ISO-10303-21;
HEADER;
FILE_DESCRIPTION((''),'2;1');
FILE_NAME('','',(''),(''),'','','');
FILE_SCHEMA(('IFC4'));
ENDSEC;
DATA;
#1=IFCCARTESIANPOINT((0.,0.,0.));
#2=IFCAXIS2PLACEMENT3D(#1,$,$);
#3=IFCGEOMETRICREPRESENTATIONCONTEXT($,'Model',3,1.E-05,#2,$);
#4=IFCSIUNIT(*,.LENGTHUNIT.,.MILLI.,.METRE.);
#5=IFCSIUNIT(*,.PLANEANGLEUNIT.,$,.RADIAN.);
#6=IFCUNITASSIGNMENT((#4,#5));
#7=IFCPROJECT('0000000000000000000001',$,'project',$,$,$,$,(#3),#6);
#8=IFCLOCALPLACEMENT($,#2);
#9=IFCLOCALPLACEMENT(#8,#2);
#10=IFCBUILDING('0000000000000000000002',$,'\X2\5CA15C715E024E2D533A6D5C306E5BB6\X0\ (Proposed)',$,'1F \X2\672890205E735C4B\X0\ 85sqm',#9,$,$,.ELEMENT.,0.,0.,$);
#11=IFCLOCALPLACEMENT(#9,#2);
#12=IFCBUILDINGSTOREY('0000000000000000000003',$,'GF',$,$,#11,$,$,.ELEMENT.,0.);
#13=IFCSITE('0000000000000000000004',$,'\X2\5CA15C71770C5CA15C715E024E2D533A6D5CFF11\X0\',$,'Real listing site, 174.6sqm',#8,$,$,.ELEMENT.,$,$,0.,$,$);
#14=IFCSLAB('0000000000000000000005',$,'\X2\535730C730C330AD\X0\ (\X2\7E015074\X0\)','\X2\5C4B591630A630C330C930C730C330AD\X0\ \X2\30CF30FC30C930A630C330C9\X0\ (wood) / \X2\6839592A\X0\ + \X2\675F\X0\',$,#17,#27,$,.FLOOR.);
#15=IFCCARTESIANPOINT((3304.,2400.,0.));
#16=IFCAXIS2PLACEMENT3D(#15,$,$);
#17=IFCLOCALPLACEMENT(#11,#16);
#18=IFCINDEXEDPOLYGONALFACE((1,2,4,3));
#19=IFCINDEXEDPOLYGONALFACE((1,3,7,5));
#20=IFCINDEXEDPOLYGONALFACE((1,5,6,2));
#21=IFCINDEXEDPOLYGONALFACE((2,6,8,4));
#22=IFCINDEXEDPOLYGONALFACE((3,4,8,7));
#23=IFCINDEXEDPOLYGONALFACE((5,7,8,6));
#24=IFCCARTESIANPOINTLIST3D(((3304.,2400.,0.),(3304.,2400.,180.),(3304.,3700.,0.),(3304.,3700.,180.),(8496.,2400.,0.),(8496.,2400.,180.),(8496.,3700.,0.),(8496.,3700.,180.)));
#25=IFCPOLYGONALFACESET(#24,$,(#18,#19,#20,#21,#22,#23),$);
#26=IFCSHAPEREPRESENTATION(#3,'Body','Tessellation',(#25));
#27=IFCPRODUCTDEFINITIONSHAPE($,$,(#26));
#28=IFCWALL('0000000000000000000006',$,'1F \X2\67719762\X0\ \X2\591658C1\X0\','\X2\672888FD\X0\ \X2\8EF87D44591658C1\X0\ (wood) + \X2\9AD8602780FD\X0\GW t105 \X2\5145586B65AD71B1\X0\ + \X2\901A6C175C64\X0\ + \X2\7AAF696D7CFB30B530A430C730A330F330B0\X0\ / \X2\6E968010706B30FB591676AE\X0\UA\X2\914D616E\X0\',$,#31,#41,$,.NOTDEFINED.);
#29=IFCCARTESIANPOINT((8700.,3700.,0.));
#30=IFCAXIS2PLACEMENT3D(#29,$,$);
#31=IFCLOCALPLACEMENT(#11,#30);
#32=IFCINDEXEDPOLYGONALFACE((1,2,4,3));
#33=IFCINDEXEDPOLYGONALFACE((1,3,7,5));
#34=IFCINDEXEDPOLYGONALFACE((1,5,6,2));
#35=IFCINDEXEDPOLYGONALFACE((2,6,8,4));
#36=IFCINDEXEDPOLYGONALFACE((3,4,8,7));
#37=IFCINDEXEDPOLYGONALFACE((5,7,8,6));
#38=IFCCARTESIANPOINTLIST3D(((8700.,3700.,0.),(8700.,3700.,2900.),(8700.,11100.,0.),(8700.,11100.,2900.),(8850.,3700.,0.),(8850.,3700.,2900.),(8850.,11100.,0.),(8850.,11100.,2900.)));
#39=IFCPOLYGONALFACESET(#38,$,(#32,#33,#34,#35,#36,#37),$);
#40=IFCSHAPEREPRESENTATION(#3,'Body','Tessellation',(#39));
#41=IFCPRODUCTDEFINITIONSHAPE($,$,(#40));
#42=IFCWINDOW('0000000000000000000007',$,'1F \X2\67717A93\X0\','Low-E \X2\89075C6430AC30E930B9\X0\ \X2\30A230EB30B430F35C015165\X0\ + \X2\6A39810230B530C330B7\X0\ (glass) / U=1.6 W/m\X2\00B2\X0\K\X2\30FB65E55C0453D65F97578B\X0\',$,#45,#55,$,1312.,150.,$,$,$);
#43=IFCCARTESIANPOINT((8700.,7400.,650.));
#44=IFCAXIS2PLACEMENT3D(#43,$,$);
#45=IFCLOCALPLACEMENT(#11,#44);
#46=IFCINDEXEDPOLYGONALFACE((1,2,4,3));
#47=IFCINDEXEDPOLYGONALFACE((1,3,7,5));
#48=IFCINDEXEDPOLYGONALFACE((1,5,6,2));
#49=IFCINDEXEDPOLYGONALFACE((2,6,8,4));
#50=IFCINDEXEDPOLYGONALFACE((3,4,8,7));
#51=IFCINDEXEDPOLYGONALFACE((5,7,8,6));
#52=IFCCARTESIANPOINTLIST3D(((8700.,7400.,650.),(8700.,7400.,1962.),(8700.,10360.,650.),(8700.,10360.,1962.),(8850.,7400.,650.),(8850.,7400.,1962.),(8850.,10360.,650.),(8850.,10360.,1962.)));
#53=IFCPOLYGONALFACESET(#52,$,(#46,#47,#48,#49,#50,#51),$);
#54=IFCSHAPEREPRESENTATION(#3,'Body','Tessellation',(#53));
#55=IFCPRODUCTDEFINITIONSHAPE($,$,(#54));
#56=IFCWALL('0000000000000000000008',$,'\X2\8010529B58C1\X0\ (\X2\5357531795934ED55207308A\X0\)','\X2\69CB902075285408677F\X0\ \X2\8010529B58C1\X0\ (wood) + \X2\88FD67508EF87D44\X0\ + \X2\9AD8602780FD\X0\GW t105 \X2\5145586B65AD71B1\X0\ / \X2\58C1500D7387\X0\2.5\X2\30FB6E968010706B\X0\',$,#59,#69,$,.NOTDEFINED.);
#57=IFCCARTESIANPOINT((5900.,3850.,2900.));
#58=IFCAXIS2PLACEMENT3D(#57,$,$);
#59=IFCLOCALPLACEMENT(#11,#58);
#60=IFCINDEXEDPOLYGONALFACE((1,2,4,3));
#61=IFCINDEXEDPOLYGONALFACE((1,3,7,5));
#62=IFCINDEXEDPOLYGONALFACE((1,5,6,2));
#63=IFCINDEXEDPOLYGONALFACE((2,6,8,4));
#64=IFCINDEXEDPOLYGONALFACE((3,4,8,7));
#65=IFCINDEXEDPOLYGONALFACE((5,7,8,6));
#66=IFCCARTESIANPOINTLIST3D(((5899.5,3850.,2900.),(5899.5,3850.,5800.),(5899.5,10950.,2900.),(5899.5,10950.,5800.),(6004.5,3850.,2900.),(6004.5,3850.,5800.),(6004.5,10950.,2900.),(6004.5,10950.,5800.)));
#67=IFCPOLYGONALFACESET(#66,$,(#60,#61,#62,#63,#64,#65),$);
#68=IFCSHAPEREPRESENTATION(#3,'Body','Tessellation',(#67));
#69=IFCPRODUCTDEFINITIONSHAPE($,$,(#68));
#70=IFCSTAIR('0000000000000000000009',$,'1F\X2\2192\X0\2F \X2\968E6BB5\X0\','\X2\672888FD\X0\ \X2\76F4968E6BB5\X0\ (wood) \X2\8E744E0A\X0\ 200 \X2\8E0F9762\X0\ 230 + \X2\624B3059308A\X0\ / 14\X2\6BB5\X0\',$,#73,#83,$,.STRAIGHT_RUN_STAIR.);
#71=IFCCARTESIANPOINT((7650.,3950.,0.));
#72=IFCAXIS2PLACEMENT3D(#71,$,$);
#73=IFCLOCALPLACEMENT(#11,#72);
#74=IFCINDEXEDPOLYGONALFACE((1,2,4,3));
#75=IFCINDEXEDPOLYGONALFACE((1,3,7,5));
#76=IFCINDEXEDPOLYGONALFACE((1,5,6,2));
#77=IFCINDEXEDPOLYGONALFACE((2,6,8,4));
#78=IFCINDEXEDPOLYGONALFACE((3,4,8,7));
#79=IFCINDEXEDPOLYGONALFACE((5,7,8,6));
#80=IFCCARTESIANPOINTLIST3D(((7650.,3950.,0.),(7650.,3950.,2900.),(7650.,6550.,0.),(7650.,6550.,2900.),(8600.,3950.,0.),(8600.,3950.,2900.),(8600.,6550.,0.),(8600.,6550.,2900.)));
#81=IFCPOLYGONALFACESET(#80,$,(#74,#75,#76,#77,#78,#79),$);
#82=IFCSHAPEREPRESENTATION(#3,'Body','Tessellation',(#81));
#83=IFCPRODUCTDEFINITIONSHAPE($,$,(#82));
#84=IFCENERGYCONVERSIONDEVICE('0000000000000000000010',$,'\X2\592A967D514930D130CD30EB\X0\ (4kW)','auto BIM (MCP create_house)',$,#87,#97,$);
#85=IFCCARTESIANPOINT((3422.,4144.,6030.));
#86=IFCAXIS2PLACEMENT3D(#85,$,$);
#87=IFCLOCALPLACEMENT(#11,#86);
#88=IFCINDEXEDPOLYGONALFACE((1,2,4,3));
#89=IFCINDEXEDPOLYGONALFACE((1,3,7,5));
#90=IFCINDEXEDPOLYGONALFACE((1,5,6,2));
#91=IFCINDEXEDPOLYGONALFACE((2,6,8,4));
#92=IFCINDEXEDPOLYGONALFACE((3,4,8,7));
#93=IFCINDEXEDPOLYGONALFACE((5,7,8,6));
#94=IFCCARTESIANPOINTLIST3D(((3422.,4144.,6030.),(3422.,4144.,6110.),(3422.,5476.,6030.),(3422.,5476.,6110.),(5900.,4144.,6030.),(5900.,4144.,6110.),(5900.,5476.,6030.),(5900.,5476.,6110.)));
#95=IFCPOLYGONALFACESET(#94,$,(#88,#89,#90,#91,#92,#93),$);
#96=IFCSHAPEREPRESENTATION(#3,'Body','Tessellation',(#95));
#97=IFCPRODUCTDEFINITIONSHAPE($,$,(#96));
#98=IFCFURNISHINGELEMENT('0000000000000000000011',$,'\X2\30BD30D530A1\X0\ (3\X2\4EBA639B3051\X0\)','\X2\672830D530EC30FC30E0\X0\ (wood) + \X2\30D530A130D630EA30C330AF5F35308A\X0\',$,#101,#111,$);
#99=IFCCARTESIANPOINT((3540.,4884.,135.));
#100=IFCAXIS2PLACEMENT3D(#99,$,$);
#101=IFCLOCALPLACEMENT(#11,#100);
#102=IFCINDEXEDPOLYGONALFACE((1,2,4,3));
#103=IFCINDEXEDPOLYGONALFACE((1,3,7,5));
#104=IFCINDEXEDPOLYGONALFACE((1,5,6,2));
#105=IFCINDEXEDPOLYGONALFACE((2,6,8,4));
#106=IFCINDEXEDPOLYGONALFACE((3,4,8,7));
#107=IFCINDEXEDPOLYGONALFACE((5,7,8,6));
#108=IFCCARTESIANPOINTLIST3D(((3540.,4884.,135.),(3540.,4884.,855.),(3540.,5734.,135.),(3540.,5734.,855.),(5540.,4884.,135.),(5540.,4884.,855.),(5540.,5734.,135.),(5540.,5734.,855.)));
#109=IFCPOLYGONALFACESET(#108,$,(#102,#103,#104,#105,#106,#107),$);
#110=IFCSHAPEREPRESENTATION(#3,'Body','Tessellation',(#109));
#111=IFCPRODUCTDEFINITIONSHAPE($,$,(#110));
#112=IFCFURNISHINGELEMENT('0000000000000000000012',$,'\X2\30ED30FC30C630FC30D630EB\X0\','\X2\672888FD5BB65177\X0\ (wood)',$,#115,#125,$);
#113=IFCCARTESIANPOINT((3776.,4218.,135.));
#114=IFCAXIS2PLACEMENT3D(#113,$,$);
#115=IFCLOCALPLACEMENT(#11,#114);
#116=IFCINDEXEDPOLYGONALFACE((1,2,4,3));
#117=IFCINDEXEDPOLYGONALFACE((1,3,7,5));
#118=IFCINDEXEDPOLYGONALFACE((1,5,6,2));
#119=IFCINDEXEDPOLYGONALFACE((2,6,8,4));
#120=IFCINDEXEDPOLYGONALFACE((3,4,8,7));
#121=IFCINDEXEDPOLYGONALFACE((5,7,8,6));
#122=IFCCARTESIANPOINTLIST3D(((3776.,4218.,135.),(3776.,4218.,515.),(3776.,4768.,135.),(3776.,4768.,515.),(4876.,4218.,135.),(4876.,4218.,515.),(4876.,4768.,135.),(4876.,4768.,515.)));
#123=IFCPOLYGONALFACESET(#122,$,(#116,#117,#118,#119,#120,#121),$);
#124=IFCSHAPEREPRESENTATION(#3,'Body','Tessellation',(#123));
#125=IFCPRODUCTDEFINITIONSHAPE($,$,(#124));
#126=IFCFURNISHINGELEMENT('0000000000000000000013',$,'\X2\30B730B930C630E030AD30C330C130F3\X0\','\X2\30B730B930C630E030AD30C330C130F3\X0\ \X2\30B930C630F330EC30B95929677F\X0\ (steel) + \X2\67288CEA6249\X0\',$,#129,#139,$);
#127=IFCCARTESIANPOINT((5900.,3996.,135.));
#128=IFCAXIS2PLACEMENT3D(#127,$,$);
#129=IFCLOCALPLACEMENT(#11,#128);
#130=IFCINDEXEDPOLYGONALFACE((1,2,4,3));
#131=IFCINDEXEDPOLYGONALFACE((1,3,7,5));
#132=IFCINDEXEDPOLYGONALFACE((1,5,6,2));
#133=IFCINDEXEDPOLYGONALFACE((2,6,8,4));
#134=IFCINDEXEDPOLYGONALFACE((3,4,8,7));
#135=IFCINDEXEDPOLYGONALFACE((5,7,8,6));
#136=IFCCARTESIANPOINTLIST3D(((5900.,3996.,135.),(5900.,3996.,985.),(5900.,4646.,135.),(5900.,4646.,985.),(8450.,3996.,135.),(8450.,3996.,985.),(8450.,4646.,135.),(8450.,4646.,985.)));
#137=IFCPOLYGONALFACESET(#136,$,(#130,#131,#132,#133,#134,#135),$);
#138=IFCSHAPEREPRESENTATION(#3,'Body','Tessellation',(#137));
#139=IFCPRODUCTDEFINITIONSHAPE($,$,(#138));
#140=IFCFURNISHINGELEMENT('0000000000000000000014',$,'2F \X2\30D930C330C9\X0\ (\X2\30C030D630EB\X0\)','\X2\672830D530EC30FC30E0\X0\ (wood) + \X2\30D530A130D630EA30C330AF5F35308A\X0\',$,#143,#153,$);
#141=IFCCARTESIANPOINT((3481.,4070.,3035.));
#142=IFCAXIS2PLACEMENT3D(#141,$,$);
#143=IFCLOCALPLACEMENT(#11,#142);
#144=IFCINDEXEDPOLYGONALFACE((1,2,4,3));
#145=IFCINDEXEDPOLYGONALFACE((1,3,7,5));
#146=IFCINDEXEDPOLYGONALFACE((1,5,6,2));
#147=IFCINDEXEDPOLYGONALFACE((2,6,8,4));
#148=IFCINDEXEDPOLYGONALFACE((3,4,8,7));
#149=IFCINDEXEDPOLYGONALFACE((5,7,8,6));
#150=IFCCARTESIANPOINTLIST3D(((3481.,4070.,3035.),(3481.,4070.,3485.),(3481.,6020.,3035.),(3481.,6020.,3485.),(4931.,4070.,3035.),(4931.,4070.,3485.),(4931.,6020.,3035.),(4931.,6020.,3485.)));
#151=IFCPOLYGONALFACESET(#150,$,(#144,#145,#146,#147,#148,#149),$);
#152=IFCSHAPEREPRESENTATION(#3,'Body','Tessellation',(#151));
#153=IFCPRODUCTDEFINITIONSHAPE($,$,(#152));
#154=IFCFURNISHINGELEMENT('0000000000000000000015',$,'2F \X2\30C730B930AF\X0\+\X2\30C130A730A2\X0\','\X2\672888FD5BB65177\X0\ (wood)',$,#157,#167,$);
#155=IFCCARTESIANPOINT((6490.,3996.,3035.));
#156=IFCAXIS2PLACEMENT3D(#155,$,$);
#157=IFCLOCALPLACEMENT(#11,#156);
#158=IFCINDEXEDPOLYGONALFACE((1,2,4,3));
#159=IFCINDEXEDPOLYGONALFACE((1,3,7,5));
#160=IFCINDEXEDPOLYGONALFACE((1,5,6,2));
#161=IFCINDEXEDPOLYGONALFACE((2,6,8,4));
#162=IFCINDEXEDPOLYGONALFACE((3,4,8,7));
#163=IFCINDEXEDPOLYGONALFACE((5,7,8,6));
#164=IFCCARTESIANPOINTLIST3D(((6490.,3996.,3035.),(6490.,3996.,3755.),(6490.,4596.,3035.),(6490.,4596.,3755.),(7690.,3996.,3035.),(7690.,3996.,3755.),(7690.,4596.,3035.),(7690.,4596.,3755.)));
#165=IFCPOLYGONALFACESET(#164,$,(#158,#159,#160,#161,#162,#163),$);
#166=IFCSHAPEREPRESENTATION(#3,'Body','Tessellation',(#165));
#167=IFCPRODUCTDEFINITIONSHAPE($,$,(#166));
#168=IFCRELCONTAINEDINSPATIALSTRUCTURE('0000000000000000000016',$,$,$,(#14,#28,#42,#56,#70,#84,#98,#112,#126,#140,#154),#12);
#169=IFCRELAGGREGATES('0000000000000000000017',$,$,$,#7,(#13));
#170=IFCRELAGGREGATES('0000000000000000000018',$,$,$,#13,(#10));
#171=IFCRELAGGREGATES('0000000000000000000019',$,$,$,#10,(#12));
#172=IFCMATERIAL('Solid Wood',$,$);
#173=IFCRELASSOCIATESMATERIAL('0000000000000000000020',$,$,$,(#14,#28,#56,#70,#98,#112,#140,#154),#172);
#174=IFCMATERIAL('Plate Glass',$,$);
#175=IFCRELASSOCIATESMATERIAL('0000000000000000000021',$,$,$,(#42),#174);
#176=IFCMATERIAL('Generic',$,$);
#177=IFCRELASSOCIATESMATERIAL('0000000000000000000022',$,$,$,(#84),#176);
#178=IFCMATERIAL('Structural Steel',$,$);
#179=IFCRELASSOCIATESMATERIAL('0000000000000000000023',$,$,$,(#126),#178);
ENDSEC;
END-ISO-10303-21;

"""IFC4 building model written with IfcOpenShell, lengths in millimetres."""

from ifc_helpers import new_model, si_unit, frame, frame_2d, origin, place, context, project, spatial, rectangle, extrude, material, element, fill, save


model = new_model("IFC4")

# Units and contexts
model_context = context("Model", 3, precision=1e-05, world=origin())
ifc_project = project(units=[si_unit("LENGTHUNIT", "METRE", prefix="MILLI"), si_unit("PLANEANGLEUNIT", "RADIAN")], contexts=[model_context])

# Site, building, storey
site_placement = place(None, origin())
site = spatial("IfcSite", under=ifc_project, at=site_placement, Name="岡山県岡山市中区浜１", ObjectType="Real listing site, 174.6sqm", CompositionType="ELEMENT", RefElevation=0.0)
building_placement = place(site_placement, origin())
building = spatial("IfcBuilding", under=site, at=building_placement, Name="岡山市中区浜の家 (Proposed)", ObjectType="1F 木造平屋 85sqm", CompositionType="ELEMENT", ElevationOfRefHeight=0.0, ElevationOfTerrain=0.0)
storey_placement = place(building_placement, origin())
storey = spatial("IfcBuildingStorey", under=building, at=storey_placement, Name="GF", CompositionType="ELEMENT", Elevation=0.0)

# Slab
ifc_material_1 = material(Name="Solid Wood")
slab_placement = place(storey_placement, frame((3304.0, 2400.0, 0.0)))
element("IfcSlab", 1, at=slab_placement, inside=storey, material=ifc_material_1, Name="南デッキ (縁側)", Description="屋外ウッドデッキ ハードウッド (wood) / 根太 + 束", PredefinedType="FLOOR", context=model_context, shape_type="SweptSolid", body=[
    extrude(rectangle(XDim=5192.0, YDim=1300.0, at=frame_2d((2596.0, 650.0))), frame((3304.0, 2400.0, 0.0)), (0.0, 0.0, 1.0), 180.0),
])

# Wall, opening, window
wall_1_placement = place(storey_placement, frame((8700.0, 3700.0, 0.0)))
wall_1 = element("IfcWall", 2, at=wall_1_placement, inside=storey, material=ifc_material_1, Name="1F 東面 外壁", Description="木製 軸組外壁 (wood) + 高性能GW t105 充填断熱 + 通気層 + 窯業系サイディング / 準耐火・外皮UA配慮", PredefinedType="NOTDEFINED", context=model_context, shape_type="SweptSolid", body=[
    extrude(rectangle(XDim=150.0, YDim=7400.0, at=frame_2d((75.0, 3700.0))), frame((8700.0, 3700.0, 0.0)), (0.0, 0.0, 1.0), 2900.0),
])
opening_1_placement = place(storey_placement, frame((8700.0, 7400.0, 650.0)))
opening_1 = element("IfcOpeningElement", 3, at=opening_1_placement, cuts=wall_1, PredefinedType="NOTDEFINED", context=model_context, shape_type="SweptSolid", body=[
    extrude(rectangle(XDim=150.0, YDim=2960.0, at=frame_2d((75.0, 1480.0))), frame((8700.0, 7400.0, 650.0)), (0.0, 0.0, 1.0), 1312.0),
])
ifc_material_2 = material(Name="Plate Glass")
window_1_placement = place(storey_placement, frame((8700.0, 7400.0, 650.0)))
window_1 = element("IfcWindow", 4, at=window_1_placement, inside=storey, material=ifc_material_2, Name="1F 東窓", Description="Low-E 複層ガラス アルゴン封入 + 樹脂サッシ (glass) / U=1.6 W/m²K・日射取得型", OverallHeight=1312.0, OverallWidth=150.0, context=model_context, shape_type="SweptSolid", body=[
    extrude(rectangle(XDim=150.0, YDim=2960.0, at=frame_2d((75.0, 1480.0))), frame((8700.0, 7400.0, 650.0)), (0.0, 0.0, 1.0), 1312.0),
])
fill(opening_1, window_1)

# Wall
wall_2_placement = place(storey_placement, frame((5900.0, 3850.0, 2900.0)))
element("IfcWall", 5, at=wall_2_placement, inside=storey, material=ifc_material_1, Name="耐力壁 (南北間仕切り)", Description="構造用合板 耐力壁 (wood) + 製材軸組 + 高性能GW t105 充填断熱 / 壁倍率2.5・準耐火", PredefinedType="NOTDEFINED", context=model_context, shape_type="SweptSolid", body=[
    extrude(rectangle(XDim=105.0, YDim=7100.0, at=frame_2d((52.0, 3550.0))), frame((5900.0, 3850.0, 2900.0)), (0.0, 0.0, 1.0), 2900.0),
])

# Stair
stair_placement = place(storey_placement, frame((7650.0, 3950.0, 0.0)))
element("IfcStair", 6, at=stair_placement, inside=storey, material=ifc_material_1, Name="1F→2F 階段", Description="木製 直階段 (wood) 蹴上 200 踏面 230 + 手すり / 14段", PredefinedType="STRAIGHT_RUN_STAIR", context=model_context, shape_type="SweptSolid", body=[
    extrude(rectangle(XDim=950.0, YDim=2600.0, at=frame_2d((475.0, 1300.0))), frame((7650.0, 3950.0, 0.0)), (0.0, 0.0, 1.0), 2900.0),
])

# Energy conversion device
ifc_material_3 = material(Name="Generic")
energy_conversion_device_placement = place(storey_placement, frame((3422.0, 4144.0, 6030.0)))
element("IfcEnergyConversionDevice", 7, at=energy_conversion_device_placement, inside=storey, material=ifc_material_3, Name="太陽光パネル (4kW)", Description="auto BIM (MCP create_house)", context=model_context, shape_type="SweptSolid", body=[
    extrude(rectangle(XDim=2478.0, YDim=1332.0, at=frame_2d((1239.0, 666.0))), frame((3422.0, 4144.0, 6030.0)), (0.0, 0.0, 1.0), 80.0),
])

# Furnishing elements
furnishing_1_placement = place(storey_placement, frame((3540.0, 4884.0, 135.0)))
element("IfcFurnishingElement", 8, at=furnishing_1_placement, inside=storey, material=ifc_material_1, Name="ソファ (3人掛け)", Description="木フレーム (wood) + ファブリック張り", context=model_context, shape_type="SweptSolid", body=[
    extrude(rectangle(XDim=2000.0, YDim=850.0, at=frame_2d((1000.0, 425.0))), frame((3540.0, 4884.0, 135.0)), (0.0, 0.0, 1.0), 720.0),
])
furnishing_2_placement = place(storey_placement, frame((3776.0, 4218.0, 135.0)))
element("IfcFurnishingElement", 9, at=furnishing_2_placement, inside=storey, material=ifc_material_1, Name="ローテーブル", Description="木製家具 (wood)", context=model_context, shape_type="SweptSolid", body=[
    extrude(rectangle(XDim=1100.0, YDim=550.0, at=frame_2d((550.0, 275.0))), frame((3776.0, 4218.0, 135.0)), (0.0, 0.0, 1.0), 380.0),
])
ifc_material_4 = material(Name="Structural Steel")
furnishing_3_placement = place(storey_placement, frame((5900.0, 3996.0, 135.0)))
element("IfcFurnishingElement", 10, at=furnishing_3_placement, inside=storey, material=ifc_material_4, Name="システムキッチン", Description="システムキッチン ステンレス天板 (steel) + 木質扉", context=model_context, shape_type="SweptSolid", body=[
    extrude(rectangle(XDim=2550.0, YDim=650.0, at=frame_2d((1275.0, 325.0))), frame((5900.0, 3996.0, 135.0)), (0.0, 0.0, 1.0), 850.0),
])
furnishing_4_placement = place(storey_placement, frame((3481.0, 4070.0, 3035.0)))
element("IfcFurnishingElement", 11, at=furnishing_4_placement, inside=storey, material=ifc_material_1, Name="2F ベッド (ダブル)", Description="木フレーム (wood) + ファブリック張り", context=model_context, shape_type="SweptSolid", body=[
    extrude(rectangle(XDim=1450.0, YDim=1950.0, at=frame_2d((725.0, 975.0))), frame((3481.0, 4070.0, 3035.0)), (0.0, 0.0, 1.0), 450.0),
])
furnishing_5_placement = place(storey_placement, frame((6490.0, 3996.0, 3035.0)))
element("IfcFurnishingElement", 12, at=furnishing_5_placement, inside=storey, material=ifc_material_1, Name="2F デスク+チェア", Description="木製家具 (wood)", context=model_context, shape_type="SweptSolid", body=[
    extrude(rectangle(XDim=1200.0, YDim=600.0, at=frame_2d((600.0, 300.0))), frame((6490.0, 3996.0, 3035.0)), (0.0, 0.0, 1.0), 720.0),
])

save(model, "model.ifc")
